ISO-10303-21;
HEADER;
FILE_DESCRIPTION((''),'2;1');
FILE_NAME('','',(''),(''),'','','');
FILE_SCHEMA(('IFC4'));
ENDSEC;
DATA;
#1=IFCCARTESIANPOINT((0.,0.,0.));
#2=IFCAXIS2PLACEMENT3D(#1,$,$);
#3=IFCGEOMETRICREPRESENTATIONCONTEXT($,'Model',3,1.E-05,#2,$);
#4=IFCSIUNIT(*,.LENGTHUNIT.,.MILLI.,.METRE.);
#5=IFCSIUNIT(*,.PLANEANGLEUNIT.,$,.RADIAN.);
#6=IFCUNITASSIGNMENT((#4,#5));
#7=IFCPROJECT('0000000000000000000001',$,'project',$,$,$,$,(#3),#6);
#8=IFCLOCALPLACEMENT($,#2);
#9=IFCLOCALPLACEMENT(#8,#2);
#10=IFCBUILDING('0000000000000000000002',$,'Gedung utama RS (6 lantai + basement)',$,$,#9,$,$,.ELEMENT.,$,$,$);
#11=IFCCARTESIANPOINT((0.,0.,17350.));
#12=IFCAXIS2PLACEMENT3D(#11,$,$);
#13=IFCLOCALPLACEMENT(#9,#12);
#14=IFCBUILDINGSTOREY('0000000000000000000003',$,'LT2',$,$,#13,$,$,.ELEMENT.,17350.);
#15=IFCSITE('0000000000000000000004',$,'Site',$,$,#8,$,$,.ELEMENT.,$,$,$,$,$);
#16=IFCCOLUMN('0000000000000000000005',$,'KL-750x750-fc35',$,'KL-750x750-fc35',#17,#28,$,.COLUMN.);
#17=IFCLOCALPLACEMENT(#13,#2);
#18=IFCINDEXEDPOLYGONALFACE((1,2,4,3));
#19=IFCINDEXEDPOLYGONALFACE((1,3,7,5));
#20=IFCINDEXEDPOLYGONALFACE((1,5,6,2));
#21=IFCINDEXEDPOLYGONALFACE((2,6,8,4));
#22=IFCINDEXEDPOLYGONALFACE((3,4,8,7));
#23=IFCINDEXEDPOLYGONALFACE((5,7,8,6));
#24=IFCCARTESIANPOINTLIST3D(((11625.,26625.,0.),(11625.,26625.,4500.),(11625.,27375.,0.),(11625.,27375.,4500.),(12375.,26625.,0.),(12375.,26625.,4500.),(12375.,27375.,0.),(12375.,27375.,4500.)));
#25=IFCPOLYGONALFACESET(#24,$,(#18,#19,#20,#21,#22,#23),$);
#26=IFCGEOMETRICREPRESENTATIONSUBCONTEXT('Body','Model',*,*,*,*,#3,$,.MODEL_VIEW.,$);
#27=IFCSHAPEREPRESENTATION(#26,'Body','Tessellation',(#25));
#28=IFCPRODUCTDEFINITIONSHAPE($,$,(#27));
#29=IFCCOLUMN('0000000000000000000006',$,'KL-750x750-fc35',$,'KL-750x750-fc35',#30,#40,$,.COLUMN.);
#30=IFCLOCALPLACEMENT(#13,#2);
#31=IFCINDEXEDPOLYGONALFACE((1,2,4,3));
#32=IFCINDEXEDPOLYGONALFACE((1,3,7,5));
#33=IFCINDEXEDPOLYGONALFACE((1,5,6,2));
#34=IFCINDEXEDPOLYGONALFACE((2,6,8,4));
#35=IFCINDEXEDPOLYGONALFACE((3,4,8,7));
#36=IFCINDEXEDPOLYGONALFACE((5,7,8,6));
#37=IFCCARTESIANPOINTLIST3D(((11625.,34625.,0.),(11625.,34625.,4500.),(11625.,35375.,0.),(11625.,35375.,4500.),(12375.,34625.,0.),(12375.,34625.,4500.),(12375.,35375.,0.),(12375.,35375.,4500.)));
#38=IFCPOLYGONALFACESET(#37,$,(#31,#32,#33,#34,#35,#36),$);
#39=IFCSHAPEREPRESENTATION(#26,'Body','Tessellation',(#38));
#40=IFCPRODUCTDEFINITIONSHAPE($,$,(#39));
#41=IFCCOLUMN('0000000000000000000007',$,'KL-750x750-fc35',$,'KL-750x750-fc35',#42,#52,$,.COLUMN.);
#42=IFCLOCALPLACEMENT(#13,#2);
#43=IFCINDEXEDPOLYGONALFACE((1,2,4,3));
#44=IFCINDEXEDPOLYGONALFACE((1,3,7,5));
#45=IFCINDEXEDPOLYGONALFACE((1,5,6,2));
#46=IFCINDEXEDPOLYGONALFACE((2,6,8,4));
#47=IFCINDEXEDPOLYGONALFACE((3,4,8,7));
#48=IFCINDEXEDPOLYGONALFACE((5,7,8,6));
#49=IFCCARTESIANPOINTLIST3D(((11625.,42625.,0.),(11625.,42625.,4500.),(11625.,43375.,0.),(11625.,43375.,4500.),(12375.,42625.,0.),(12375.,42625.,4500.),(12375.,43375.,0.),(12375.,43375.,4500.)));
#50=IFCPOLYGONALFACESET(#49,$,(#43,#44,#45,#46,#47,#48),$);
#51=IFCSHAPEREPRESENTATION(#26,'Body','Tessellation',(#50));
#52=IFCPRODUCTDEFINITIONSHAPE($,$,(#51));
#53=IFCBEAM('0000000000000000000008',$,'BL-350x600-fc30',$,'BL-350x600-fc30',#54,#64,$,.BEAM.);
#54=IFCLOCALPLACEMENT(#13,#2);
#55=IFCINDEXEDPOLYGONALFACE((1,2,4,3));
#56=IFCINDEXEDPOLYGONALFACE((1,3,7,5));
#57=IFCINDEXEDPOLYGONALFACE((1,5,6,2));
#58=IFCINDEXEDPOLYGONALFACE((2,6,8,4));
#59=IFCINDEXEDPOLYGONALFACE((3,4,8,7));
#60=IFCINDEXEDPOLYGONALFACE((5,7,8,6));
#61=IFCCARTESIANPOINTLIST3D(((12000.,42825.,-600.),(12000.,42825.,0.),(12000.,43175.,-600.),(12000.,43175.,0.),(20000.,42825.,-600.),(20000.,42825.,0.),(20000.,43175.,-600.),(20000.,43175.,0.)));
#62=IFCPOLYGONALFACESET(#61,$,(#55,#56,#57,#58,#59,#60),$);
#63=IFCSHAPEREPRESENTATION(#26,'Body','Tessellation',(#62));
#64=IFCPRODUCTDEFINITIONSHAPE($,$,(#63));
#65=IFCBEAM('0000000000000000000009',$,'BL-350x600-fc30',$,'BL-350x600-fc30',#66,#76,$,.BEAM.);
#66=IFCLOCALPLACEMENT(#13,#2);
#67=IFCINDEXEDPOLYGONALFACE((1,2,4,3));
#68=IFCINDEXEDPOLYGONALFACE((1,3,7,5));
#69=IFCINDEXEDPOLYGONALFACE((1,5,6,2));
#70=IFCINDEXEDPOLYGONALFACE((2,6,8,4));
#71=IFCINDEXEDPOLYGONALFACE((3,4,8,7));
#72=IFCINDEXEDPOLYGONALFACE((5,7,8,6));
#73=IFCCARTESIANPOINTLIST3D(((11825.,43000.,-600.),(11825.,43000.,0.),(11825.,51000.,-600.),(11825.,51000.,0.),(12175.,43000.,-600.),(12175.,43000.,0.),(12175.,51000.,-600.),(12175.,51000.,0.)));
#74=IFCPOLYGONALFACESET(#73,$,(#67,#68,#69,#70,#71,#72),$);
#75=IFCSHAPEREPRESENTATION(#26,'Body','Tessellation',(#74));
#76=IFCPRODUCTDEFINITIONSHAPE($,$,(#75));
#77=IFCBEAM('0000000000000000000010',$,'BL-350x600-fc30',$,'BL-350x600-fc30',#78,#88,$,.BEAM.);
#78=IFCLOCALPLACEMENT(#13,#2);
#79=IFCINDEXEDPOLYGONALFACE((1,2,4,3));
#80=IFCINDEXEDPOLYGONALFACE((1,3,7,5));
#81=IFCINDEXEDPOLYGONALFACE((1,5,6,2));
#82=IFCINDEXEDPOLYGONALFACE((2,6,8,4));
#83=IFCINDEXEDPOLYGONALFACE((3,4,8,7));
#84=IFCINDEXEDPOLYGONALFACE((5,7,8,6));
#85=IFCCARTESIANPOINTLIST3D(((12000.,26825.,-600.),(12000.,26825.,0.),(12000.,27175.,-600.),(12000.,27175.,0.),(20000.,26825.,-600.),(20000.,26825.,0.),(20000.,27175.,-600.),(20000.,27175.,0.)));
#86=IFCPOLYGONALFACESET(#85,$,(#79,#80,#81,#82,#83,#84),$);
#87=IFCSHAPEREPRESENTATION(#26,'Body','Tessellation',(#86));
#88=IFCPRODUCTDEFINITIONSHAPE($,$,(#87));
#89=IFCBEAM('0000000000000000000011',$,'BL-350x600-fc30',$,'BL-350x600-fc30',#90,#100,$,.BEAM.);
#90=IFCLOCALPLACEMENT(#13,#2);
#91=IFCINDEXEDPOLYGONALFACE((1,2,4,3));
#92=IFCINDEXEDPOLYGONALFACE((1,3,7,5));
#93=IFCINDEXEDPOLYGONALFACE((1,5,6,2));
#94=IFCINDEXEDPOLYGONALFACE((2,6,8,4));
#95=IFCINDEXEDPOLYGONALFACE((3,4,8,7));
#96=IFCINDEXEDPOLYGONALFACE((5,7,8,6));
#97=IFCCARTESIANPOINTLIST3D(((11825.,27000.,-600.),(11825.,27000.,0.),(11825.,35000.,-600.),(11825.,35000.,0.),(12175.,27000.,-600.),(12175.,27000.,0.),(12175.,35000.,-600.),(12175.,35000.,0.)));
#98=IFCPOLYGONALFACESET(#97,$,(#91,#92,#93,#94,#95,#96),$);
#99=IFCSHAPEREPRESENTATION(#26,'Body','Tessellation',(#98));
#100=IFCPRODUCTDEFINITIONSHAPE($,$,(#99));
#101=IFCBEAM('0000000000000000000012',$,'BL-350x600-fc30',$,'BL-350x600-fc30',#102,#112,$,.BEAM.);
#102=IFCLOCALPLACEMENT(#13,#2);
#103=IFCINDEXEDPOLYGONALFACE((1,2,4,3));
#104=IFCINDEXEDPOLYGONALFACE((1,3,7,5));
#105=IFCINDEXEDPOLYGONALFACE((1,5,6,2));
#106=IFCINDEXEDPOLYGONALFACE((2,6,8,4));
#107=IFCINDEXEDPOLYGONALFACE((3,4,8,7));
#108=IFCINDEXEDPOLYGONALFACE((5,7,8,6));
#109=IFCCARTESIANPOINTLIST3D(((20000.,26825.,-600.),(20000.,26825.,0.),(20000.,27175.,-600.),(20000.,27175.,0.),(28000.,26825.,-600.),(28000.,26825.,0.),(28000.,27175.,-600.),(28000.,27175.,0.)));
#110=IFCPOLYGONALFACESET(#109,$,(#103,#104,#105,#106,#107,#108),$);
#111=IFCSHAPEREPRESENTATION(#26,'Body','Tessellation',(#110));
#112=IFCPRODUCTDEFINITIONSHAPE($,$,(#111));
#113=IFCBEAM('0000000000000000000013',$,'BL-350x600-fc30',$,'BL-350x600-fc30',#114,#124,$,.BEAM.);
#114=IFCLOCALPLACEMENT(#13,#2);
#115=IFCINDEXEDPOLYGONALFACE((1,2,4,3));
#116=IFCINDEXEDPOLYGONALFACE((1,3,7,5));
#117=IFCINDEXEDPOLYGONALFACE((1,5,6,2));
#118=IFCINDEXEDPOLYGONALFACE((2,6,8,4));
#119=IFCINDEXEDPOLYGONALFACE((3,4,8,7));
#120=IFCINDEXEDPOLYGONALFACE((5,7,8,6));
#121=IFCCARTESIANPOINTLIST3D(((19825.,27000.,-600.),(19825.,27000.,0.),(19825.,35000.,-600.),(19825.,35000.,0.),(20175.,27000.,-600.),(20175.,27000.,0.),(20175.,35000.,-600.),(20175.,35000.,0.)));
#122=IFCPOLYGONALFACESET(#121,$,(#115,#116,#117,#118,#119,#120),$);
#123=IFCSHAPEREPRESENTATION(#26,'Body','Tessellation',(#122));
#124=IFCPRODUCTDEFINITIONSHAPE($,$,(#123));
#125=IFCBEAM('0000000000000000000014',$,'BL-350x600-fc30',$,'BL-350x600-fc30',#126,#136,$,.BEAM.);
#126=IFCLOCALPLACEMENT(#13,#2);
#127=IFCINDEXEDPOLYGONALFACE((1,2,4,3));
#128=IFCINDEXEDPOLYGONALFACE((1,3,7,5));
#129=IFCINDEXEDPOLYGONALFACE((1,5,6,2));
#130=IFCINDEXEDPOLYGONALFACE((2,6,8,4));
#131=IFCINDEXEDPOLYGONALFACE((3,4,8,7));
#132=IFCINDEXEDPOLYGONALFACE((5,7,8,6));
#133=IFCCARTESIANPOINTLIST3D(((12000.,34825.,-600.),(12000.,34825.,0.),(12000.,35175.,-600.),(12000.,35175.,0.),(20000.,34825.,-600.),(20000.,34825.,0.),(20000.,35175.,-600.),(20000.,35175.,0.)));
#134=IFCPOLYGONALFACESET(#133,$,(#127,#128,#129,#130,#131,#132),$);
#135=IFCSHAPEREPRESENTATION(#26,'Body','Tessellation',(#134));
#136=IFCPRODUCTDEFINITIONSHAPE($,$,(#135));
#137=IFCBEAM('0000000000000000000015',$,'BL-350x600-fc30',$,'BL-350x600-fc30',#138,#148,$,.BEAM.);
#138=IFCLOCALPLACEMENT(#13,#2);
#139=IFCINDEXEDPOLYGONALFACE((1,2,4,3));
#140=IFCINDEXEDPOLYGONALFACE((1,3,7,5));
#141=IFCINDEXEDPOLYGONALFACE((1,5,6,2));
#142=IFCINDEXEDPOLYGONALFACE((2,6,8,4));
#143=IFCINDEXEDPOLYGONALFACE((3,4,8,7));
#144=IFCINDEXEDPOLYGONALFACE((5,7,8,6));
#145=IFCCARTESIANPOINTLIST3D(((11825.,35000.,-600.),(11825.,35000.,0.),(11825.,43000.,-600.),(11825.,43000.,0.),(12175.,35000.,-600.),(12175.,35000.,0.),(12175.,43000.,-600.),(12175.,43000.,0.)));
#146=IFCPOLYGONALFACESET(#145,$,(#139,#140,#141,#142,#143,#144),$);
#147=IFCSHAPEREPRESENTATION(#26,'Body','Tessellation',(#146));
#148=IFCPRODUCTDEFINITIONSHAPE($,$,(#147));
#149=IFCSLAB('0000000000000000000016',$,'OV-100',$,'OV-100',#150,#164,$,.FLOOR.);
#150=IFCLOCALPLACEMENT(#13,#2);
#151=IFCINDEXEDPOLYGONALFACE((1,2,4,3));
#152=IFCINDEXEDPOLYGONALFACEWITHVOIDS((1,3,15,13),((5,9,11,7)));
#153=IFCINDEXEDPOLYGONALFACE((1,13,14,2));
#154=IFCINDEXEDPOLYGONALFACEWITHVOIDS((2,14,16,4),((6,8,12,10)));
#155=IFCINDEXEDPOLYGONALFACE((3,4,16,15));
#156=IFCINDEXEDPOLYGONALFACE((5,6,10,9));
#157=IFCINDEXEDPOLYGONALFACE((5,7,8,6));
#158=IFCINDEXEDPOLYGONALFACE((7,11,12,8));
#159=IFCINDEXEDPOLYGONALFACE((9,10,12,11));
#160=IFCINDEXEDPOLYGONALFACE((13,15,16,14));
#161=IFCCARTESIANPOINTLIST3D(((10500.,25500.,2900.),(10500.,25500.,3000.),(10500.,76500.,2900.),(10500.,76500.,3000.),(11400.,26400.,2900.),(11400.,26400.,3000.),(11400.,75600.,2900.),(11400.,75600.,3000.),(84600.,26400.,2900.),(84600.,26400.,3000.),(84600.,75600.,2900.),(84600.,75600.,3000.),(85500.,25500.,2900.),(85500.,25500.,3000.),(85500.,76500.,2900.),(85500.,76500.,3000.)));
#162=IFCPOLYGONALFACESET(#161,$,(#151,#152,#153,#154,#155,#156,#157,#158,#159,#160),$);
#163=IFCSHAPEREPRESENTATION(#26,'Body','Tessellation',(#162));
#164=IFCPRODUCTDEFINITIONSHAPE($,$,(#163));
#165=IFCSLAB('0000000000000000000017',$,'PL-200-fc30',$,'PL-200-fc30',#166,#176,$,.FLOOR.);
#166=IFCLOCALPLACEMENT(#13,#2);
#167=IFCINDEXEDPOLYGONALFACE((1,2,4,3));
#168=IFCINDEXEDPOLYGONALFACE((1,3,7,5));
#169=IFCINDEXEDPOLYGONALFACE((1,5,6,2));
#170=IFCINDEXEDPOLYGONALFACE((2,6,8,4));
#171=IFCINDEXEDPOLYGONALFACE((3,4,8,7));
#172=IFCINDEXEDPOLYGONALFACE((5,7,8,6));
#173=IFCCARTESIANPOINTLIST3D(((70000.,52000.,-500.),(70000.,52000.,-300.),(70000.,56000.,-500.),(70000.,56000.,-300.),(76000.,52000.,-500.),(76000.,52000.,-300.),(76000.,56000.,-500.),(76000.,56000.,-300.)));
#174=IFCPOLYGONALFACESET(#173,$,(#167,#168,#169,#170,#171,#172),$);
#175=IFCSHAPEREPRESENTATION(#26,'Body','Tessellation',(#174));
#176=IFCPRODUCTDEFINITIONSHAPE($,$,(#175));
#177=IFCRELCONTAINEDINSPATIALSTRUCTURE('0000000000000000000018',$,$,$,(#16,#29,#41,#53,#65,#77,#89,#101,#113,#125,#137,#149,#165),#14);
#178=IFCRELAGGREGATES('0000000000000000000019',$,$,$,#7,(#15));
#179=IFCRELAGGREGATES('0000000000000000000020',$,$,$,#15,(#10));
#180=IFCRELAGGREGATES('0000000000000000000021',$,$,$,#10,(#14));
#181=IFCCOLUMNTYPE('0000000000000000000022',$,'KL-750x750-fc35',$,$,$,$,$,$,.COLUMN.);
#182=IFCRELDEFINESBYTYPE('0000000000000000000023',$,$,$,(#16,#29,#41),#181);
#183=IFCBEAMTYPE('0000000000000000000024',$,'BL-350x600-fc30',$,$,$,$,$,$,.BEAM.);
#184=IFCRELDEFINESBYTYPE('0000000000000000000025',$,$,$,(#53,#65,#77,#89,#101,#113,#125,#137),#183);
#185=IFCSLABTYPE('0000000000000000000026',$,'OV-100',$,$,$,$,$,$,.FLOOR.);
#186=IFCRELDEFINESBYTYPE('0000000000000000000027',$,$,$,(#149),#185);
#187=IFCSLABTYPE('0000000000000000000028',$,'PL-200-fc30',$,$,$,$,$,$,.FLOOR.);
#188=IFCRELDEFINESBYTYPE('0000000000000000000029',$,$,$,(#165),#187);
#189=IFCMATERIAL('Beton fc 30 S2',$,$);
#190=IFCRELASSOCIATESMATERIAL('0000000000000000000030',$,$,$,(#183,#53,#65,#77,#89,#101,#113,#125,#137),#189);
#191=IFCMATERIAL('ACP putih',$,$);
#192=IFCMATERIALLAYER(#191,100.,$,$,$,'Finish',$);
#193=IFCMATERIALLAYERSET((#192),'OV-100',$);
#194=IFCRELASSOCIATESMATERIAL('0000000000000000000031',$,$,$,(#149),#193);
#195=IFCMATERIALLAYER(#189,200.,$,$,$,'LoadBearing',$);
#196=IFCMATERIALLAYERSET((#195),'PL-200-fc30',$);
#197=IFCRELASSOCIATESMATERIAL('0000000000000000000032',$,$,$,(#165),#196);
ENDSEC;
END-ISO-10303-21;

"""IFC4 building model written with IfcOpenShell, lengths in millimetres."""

from ifc_helpers import new_model, si_unit, frame, origin, origin_2d, place, context, subcontext, project, spatial, polyline, rectangle, outline, extrude, material, layer, layer_set, layer_usage, material_profile, profile_set, profile_usage, type_object, element, save


model = new_model("IFC4")

# Units and contexts
model_context = context("Model", 3, precision=1e-05, world=origin())
body_context = subcontext(model_context, "Body", "Model", "MODEL_VIEW")
ifc_project = project(units=[si_unit("LENGTHUNIT", "METRE", prefix="MILLI"), si_unit("PLANEANGLEUNIT", "RADIAN")], contexts=[model_context])

# Site, building, storey
site_placement = place(None, origin())
site = spatial("IfcSite", under=ifc_project, at=site_placement, Name="Site", CompositionType="ELEMENT")
building_placement = place(site_placement, origin())
building = spatial("IfcBuilding", under=site, at=building_placement, Name="Gedung utama RS (6 lantai + basement)", CompositionType="ELEMENT")
storey_placement = place(building_placement, frame((0.0, 0.0, 17350.0)))
storey = spatial("IfcBuildingStorey", under=building, at=storey_placement, Name="LT2", CompositionType="ELEMENT", Elevation=17350.0)

# Columns
ifc_material_profile_1 = material_profile(None, rectangle(XDim=750.0, YDim=750.0, at=origin_2d()), Name="KL-750x750-fc35")
ifc_profile_set_1 = profile_set([ifc_material_profile_1], Name="KL-750x750-fc35")
ifc_profile_usage_1 = profile_usage(ifc_profile_set_1, cardinal=5)
column_type = type_object("IfcColumnType", Name="KL-750x750-fc35", PredefinedType="COLUMN", material=ifc_profile_set_1)
for number, where, z_axis, x_axis, name in (
    (1, (12000.0, 27000.0, 0.0), (0.0, 0.0, 1.0), (1.0, 0.0, 0.0), "KL-750x750-fc35"),
    (2, (12000.0, 35000.0, 0.0), (0.0, 0.0, 1.0), (1.0, 0.0, 0.0), "KL-750x750-fc35"),
    (3, (12000.0, 43000.0, 0.0), (0.0, 0.0, 1.0), (1.0, 0.0, 0.0), "KL-750x750-fc35"),
):
    element("IfcColumn", number, at=place(storey_placement, frame(where, z_axis=z_axis, x_axis=x_axis)), inside=storey, type_object=column_type, material=ifc_profile_usage_1, Name=name, ObjectType="KL-750x750-fc35", PredefinedType="COLUMN", context=body_context, shape_type="SweptSolid", body=[
        extrude(rectangle(XDim=750.0, YDim=750.0, at=origin_2d()), origin(), (0.0, 0.0, 1.0), 4500.0),
    ])

# Beams
ifc_material_1 = material(Name="Beton fc 30 S2")
ifc_material_profile_2 = material_profile(ifc_material_1, rectangle(XDim=350.0, YDim=600.0, at=origin_2d()), Name="BL-350x600-fc30")
ifc_profile_set_2 = profile_set([ifc_material_profile_2], Name="BL-350x600-fc30")
ifc_profile_usage_2 = profile_usage(ifc_profile_set_2, cardinal=8)
beam_type = type_object("IfcBeamType", Name="BL-350x600-fc30", PredefinedType="BEAM", material=ifc_profile_set_2)
beam_1_placement = place(storey_placement, frame((12000.0, 43000.0, -300.0)))
element("IfcBeam", 4, at=beam_1_placement, inside=storey, type_object=beam_type, material=ifc_profile_usage_2, Name="BL-350x600-fc30", ObjectType="BL-350x600-fc30", PredefinedType="BEAM", context=body_context, shape_type="SweptSolid", body=[
    extrude(rectangle(XDim=350.0, YDim=600.0, at=origin_2d()), frame((0.0, 0.0, 0.0), z_axis=(1.0, 0.0, 0.0), x_axis=(0.0, 1.0, 0.0)), (0.0, 0.0, 1.0), 8000.0),
])
beam_2_placement = place(storey_placement, frame((12000.0, 43000.0, -300.0)))
element("IfcBeam", 5, at=beam_2_placement, inside=storey, type_object=beam_type, material=ifc_profile_usage_2, Name="BL-350x600-fc30", ObjectType="BL-350x600-fc30", PredefinedType="BEAM", context=body_context, shape_type="SweptSolid", body=[
    extrude(rectangle(XDim=350.0, YDim=600.0, at=origin_2d()), frame((0.0, 0.0, 0.0), z_axis=(0.0, 1.0, 0.0), x_axis=(-1.0, 0.0, 0.0)), (0.0, 0.0, 1.0), 8000.0),
])
beam_3_placement = place(storey_placement, frame((12000.0, 27000.0, -300.0)))
element("IfcBeam", 6, at=beam_3_placement, inside=storey, type_object=beam_type, material=ifc_profile_usage_2, Name="BL-350x600-fc30", ObjectType="BL-350x600-fc30", PredefinedType="BEAM", context=body_context, shape_type="SweptSolid", body=[
    extrude(rectangle(XDim=350.0, YDim=600.0, at=origin_2d()), frame((0.0, 0.0, 0.0), z_axis=(1.0, 0.0, 0.0), x_axis=(0.0, 1.0, 0.0)), (0.0, 0.0, 1.0), 8000.0),
])
beam_4_placement = place(storey_placement, frame((12000.0, 27000.0, -300.0)))
element("IfcBeam", 7, at=beam_4_placement, inside=storey, type_object=beam_type, material=ifc_profile_usage_2, Name="BL-350x600-fc30", ObjectType="BL-350x600-fc30", PredefinedType="BEAM", context=body_context, shape_type="SweptSolid", body=[
    extrude(rectangle(XDim=350.0, YDim=600.0, at=origin_2d()), frame((0.0, 0.0, 0.0), z_axis=(0.0, 1.0, 0.0), x_axis=(-1.0, 0.0, 0.0)), (0.0, 0.0, 1.0), 8000.0),
])
beam_5_placement = place(storey_placement, frame((20000.0, 27000.0, -300.0)))
element("IfcBeam", 8, at=beam_5_placement, inside=storey, type_object=beam_type, material=ifc_profile_usage_2, Name="BL-350x600-fc30", ObjectType="BL-350x600-fc30", PredefinedType="BEAM", context=body_context, shape_type="SweptSolid", body=[
    extrude(rectangle(XDim=350.0, YDim=600.0, at=origin_2d()), frame((0.0, 0.0, 0.0), z_axis=(1.0, 0.0, 0.0), x_axis=(0.0, 1.0, 0.0)), (0.0, 0.0, 1.0), 8000.0),
])
beam_6_placement = place(storey_placement, frame((20000.0, 27000.0, -300.0)))
element("IfcBeam", 9, at=beam_6_placement, inside=storey, type_object=beam_type, material=ifc_profile_usage_2, Name="BL-350x600-fc30", ObjectType="BL-350x600-fc30", PredefinedType="BEAM", context=body_context, shape_type="SweptSolid", body=[
    extrude(rectangle(XDim=350.0, YDim=600.0, at=origin_2d()), frame((0.0, 0.0, 0.0), z_axis=(0.0, 1.0, 0.0), x_axis=(-1.0, 0.0, 0.0)), (0.0, 0.0, 1.0), 8000.0),
])
beam_7_placement = place(storey_placement, frame((12000.0, 35000.0, -300.0)))
element("IfcBeam", 10, at=beam_7_placement, inside=storey, type_object=beam_type, material=ifc_profile_usage_2, Name="BL-350x600-fc30", ObjectType="BL-350x600-fc30", PredefinedType="BEAM", context=body_context, shape_type="SweptSolid", body=[
    extrude(rectangle(XDim=350.0, YDim=600.0, at=origin_2d()), frame((0.0, 0.0, 0.0), z_axis=(1.0, 0.0, 0.0), x_axis=(0.0, 1.0, 0.0)), (0.0, 0.0, 1.0), 8000.0),
])
beam_8_placement = place(storey_placement, frame((12000.0, 35000.0, -300.0)))
element("IfcBeam", 11, at=beam_8_placement, inside=storey, type_object=beam_type, material=ifc_profile_usage_2, Name="BL-350x600-fc30", ObjectType="BL-350x600-fc30", PredefinedType="BEAM", context=body_context, shape_type="SweptSolid", body=[
    extrude(rectangle(XDim=350.0, YDim=600.0, at=origin_2d()), frame((0.0, 0.0, 0.0), z_axis=(0.0, 1.0, 0.0), x_axis=(-1.0, 0.0, 0.0)), (0.0, 0.0, 1.0), 8000.0),
])

# Slabs
ifc_material_2 = material(Name="ACP putih")
ifc_layer_1 = layer(ifc_material_2, 100.0, Category="Finish")
ifc_layer_set_1 = layer_set([ifc_layer_1], Name="OV-100")
ifc_layer_usage_1 = layer_usage(ifc_layer_set_1, "AXIS3", "NEGATIVE", 3000.0)
slab_type_1 = type_object("IfcSlabType", Name="OV-100", PredefinedType="FLOOR")
slab_1_placement = place(storey_placement, origin())
element("IfcSlab", 12, at=slab_1_placement, inside=storey, type_object=slab_type_1, material=ifc_layer_usage_1, Name="OV-100", ObjectType="OV-100", PredefinedType="FLOOR", context=body_context, shape_type="SweptSolid", body=[
    extrude(outline(polyline([(85500.0, 76500.0), (10500.0, 76500.0), (10500.0, 25500.0), (85500.0, 25500.0), (85500.0, 76500.0)]), holes=[polyline([(84600.0, 26400.0), (11400.0, 26400.0), (11400.0, 75600.0), (84600.0, 75600.0), (84600.0, 26400.0)])]), frame((0.0, 0.0, 2900.0)), (0.0, 0.0, 1.0), 100.0),
])
ifc_layer_2 = layer(ifc_material_1, 200.0, Category="LoadBearing")
ifc_layer_set_2 = layer_set([ifc_layer_2], Name="PL-200-fc30")
ifc_layer_usage_2 = layer_usage(ifc_layer_set_2, "AXIS3", "NEGATIVE", -300.0)
slab_type_2 = type_object("IfcSlabType", Name="PL-200-fc30", PredefinedType="FLOOR")
slab_2_placement = place(storey_placement, origin())
element("IfcSlab", 13, at=slab_2_placement, inside=storey, type_object=slab_type_2, material=ifc_layer_usage_2, Name="PL-200-fc30", ObjectType="PL-200-fc30", PredefinedType="FLOOR", context=body_context, shape_type="SweptSolid", body=[
    extrude(outline(polyline([(76000.0, 52000.0), (76000.0, 56000.0), (70000.0, 56000.0), (70000.0, 52000.0), (76000.0, 52000.0)])), frame((0.0, 0.0, -500.0)), (0.0, 0.0, 1.0), 200.0),
])

save(model, "model.ifc")
